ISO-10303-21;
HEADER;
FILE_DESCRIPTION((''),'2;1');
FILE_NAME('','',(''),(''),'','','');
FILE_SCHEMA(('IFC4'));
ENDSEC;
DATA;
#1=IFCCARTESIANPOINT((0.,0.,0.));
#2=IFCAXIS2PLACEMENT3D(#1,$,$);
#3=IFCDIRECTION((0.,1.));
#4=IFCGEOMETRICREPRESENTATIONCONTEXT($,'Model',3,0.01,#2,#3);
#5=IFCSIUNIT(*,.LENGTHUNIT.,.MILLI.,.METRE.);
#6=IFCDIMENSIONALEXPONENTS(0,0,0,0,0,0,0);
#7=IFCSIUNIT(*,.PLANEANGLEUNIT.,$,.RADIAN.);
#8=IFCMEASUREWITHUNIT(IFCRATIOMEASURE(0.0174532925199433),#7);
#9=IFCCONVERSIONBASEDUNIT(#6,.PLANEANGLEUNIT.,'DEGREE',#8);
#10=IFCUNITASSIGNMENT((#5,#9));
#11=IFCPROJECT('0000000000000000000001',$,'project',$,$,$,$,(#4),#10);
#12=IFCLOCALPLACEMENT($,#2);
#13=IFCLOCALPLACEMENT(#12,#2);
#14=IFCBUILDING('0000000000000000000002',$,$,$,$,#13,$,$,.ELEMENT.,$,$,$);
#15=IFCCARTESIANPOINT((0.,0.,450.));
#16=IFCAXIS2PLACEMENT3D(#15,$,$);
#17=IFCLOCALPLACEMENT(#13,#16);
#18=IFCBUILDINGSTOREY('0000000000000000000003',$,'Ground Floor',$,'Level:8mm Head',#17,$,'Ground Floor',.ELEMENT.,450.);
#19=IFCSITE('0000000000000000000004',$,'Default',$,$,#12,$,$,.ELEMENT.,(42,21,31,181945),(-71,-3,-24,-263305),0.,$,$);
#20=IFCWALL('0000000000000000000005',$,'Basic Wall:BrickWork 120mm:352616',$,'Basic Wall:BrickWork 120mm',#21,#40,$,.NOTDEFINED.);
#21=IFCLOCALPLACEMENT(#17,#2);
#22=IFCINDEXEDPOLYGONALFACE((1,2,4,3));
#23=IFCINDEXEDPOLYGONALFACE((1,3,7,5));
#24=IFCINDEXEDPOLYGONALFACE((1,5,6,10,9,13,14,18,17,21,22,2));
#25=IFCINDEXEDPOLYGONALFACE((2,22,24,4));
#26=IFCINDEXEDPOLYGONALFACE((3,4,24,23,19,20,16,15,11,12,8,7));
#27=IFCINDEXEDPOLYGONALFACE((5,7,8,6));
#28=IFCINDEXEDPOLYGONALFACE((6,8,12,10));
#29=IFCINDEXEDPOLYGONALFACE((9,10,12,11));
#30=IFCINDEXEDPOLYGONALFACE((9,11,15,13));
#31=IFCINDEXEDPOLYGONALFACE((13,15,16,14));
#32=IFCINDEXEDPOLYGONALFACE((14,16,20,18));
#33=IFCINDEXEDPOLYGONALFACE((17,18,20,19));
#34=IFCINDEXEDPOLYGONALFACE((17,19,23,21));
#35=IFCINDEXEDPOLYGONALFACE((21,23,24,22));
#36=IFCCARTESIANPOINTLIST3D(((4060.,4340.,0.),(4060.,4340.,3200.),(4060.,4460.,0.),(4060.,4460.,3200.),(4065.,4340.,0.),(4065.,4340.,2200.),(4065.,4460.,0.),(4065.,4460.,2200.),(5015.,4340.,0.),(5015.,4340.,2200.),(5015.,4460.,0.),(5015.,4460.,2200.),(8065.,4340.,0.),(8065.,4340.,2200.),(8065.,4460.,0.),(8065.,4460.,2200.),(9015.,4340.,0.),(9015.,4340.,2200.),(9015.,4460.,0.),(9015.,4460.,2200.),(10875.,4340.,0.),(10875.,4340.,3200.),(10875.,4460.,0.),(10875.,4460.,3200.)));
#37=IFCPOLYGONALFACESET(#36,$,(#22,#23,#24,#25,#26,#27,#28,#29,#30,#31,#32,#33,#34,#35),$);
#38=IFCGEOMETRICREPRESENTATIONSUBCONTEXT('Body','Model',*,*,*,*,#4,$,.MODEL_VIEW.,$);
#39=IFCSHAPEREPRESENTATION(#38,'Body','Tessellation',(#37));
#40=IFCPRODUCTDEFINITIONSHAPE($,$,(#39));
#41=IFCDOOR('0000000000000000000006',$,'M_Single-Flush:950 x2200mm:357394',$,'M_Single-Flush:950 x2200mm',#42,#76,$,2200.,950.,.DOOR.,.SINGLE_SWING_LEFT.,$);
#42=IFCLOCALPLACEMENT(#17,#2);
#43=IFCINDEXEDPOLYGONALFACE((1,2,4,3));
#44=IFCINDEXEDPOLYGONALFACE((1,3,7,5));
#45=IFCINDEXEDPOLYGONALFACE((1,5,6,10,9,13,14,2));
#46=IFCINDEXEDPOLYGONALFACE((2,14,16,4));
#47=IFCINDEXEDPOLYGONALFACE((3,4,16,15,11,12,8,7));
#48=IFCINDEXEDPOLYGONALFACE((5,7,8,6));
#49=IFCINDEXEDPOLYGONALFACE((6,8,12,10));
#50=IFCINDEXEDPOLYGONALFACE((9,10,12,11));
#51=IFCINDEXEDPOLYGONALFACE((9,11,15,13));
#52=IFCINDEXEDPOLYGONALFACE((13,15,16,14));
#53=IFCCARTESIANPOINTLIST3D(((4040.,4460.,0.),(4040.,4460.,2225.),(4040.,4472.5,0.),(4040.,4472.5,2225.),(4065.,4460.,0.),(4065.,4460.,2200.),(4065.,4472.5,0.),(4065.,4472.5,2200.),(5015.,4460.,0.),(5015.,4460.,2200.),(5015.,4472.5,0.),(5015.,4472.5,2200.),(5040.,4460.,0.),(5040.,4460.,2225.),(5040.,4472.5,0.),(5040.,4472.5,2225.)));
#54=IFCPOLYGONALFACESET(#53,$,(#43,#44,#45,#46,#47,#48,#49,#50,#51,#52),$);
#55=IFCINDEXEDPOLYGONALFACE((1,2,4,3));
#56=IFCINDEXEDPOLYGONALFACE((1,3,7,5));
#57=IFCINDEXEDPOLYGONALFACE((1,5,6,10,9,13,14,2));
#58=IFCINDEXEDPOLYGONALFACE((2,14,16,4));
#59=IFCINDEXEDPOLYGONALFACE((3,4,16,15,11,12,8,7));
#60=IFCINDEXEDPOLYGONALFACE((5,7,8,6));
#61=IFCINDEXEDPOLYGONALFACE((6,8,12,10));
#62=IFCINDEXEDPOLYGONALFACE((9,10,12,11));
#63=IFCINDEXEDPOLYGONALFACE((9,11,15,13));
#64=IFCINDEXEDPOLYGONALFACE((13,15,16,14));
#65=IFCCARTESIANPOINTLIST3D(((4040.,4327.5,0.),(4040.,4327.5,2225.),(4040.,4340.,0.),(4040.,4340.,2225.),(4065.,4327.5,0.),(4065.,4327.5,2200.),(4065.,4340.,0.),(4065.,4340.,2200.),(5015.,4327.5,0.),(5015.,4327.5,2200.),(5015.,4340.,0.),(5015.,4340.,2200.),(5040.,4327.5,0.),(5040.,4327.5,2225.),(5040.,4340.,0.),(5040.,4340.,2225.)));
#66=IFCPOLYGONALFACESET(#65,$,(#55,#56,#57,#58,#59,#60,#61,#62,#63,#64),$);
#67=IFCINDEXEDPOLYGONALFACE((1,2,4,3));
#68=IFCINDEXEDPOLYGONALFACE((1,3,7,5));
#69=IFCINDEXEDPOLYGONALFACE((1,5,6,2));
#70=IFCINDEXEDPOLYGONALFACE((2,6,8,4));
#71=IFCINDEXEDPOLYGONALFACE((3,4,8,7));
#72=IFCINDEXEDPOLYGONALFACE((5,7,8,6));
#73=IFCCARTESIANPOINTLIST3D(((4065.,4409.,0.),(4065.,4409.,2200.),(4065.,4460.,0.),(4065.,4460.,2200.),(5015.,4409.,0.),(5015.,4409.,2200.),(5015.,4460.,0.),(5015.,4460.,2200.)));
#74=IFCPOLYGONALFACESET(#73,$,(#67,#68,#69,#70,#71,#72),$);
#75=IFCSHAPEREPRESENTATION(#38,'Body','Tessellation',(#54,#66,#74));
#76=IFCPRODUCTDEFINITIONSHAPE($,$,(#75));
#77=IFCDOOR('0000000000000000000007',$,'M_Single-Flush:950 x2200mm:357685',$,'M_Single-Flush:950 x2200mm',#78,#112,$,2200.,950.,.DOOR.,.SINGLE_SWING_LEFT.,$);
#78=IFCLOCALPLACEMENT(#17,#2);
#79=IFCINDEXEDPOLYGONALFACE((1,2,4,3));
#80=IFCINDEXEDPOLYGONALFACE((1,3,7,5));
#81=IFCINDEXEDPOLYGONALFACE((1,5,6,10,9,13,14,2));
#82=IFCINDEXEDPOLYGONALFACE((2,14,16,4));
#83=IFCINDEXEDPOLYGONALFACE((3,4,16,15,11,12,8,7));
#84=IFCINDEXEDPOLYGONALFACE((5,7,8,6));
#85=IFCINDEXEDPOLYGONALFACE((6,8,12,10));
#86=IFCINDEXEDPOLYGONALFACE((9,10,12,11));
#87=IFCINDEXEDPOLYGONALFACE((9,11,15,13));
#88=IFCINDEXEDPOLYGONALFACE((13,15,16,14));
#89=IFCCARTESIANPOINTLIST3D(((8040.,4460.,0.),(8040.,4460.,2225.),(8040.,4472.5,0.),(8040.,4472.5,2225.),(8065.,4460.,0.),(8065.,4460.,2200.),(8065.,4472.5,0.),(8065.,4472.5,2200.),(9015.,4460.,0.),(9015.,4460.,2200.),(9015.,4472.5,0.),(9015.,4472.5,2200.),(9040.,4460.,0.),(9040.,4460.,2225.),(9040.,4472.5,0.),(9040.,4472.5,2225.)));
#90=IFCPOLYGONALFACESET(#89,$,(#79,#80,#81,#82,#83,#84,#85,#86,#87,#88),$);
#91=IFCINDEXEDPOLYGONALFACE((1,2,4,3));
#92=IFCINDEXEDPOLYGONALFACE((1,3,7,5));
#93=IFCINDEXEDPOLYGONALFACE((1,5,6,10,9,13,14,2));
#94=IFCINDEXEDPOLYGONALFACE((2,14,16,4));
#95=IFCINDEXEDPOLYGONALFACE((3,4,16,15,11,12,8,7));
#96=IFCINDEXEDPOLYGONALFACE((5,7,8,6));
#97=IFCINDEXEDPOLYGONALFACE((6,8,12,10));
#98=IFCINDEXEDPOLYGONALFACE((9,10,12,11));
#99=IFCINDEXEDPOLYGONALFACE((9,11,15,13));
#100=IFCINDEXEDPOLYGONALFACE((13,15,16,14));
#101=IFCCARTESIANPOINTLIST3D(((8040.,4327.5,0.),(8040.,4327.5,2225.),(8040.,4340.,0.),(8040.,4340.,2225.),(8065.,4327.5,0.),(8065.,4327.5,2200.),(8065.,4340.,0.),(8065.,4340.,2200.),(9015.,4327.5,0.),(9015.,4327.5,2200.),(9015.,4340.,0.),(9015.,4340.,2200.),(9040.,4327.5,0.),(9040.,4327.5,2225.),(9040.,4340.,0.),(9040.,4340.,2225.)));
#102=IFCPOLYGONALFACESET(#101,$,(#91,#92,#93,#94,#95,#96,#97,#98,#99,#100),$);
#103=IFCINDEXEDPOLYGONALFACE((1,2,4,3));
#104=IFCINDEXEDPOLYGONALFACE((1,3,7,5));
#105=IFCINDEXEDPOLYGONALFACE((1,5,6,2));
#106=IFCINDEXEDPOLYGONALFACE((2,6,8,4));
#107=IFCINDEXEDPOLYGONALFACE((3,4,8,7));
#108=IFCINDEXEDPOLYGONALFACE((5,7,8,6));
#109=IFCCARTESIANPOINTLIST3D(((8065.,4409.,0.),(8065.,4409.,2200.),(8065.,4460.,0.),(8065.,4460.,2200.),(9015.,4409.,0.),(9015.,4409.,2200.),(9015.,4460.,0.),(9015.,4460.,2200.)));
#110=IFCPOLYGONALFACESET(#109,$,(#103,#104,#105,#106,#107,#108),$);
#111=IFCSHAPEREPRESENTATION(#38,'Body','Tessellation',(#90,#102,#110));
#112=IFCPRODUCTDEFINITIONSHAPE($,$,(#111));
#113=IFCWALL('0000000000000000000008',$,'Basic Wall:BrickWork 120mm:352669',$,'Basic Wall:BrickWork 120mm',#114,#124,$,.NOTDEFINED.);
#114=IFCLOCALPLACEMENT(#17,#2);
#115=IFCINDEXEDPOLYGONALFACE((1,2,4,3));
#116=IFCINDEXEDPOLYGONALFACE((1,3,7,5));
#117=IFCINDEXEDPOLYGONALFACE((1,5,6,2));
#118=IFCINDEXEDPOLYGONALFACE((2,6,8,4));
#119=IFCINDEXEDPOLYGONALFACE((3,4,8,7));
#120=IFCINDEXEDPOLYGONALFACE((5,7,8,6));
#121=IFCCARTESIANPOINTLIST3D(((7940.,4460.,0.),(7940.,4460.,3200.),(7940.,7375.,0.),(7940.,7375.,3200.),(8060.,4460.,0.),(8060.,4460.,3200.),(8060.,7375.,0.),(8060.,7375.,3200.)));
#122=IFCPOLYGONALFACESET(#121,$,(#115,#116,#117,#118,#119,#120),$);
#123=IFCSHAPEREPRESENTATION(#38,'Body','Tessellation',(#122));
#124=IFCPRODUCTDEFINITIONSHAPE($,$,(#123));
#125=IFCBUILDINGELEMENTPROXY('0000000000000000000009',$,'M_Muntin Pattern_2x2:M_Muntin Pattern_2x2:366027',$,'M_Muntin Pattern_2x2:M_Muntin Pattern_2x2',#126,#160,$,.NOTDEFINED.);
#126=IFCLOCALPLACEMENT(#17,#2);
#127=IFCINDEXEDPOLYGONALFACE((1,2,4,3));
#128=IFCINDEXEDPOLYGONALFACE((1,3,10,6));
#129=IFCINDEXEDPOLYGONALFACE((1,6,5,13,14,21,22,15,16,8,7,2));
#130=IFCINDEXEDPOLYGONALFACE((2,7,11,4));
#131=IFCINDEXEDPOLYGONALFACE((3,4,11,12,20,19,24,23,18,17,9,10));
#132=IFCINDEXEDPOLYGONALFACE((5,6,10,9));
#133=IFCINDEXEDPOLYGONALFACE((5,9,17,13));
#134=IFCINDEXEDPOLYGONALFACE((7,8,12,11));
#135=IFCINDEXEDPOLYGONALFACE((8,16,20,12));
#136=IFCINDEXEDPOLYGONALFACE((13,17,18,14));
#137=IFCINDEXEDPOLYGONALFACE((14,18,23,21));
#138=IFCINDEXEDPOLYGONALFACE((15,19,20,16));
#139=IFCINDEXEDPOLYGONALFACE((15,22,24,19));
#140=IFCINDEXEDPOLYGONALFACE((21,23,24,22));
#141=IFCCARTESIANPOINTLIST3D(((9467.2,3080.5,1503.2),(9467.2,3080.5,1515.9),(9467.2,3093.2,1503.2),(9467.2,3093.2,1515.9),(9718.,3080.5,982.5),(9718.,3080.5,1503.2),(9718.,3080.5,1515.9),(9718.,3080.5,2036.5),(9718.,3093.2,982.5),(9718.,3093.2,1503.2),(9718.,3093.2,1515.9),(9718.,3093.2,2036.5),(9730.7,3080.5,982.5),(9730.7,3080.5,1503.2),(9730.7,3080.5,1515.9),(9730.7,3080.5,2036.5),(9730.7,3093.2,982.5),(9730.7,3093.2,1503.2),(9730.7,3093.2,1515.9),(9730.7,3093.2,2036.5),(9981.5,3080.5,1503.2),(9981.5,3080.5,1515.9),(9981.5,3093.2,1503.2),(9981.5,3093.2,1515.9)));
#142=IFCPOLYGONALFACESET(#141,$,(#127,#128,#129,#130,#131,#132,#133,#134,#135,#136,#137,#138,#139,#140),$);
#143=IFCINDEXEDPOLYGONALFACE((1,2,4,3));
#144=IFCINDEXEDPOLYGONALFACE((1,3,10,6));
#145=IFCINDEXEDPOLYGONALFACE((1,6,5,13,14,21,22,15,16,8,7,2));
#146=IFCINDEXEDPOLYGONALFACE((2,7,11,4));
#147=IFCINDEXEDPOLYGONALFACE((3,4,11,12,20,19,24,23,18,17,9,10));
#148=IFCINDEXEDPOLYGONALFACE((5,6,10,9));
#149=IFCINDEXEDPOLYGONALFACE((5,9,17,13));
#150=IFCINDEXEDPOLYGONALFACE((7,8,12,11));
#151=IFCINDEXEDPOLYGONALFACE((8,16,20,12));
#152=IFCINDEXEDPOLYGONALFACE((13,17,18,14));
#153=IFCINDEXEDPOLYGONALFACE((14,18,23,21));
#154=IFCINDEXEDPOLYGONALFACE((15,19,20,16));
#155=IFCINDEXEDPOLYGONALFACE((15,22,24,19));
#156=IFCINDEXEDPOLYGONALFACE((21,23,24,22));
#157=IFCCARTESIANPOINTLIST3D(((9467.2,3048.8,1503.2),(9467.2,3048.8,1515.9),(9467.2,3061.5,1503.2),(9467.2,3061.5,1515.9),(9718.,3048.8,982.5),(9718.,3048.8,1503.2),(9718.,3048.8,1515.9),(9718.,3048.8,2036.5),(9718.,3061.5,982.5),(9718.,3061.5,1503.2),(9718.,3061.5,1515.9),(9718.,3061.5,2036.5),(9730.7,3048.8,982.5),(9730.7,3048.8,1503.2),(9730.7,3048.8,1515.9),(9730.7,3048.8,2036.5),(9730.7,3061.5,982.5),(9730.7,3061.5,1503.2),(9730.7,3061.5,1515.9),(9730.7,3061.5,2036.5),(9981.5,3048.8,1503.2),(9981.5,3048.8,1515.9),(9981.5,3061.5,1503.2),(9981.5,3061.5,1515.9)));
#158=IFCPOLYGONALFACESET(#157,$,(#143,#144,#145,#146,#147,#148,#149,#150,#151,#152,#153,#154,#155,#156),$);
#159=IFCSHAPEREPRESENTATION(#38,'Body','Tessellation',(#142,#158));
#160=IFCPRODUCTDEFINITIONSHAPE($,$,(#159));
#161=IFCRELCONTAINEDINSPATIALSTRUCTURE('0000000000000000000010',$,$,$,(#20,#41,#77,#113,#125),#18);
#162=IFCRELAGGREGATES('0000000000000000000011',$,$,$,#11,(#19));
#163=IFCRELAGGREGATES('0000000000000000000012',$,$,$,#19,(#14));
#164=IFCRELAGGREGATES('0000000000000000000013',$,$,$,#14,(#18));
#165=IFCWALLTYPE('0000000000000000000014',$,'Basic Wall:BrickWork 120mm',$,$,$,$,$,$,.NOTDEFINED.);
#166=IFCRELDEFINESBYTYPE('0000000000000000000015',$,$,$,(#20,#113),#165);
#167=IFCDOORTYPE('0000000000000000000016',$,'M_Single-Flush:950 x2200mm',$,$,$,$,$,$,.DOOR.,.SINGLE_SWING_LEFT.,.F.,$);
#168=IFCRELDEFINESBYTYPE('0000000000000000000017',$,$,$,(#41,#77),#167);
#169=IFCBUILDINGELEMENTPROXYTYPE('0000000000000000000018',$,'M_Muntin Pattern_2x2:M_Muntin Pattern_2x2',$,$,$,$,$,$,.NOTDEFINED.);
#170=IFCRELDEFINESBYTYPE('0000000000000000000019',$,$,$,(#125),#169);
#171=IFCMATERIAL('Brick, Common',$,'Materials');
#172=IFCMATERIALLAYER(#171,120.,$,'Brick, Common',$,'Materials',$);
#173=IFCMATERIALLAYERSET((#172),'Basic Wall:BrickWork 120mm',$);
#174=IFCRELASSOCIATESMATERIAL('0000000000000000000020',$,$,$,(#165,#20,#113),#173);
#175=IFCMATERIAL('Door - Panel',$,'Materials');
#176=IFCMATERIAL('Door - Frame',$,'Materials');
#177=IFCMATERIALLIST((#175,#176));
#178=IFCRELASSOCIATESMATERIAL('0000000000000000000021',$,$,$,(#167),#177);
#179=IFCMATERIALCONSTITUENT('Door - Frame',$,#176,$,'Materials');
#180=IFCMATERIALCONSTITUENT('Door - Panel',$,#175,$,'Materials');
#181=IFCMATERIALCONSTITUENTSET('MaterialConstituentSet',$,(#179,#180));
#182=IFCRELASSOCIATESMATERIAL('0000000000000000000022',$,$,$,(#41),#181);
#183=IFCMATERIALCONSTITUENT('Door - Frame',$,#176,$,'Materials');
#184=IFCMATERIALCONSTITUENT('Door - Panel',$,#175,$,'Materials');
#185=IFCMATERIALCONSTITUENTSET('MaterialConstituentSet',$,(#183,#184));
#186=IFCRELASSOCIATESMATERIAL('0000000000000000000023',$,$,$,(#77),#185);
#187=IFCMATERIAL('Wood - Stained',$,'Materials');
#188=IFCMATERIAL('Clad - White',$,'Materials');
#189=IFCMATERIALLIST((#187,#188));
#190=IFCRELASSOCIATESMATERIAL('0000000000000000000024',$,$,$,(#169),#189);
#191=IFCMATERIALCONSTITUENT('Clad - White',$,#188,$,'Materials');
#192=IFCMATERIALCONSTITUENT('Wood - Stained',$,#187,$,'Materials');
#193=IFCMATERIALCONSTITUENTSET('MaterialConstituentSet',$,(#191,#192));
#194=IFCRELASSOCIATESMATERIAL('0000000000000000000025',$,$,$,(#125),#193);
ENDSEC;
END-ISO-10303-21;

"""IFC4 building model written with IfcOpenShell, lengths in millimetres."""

from ifc_helpers import new_model, entity, si_unit, converted_unit, direction, frame, frame_2d, origin, place, context, subcontext, project, spatial, polyline, rectangle, outline, extrude, source, transform, mapped, material, material_list, layer, layer_set, layer_usage, constituent, constituent_set, type_object, type_shapes, element, fill, save


model = new_model("IFC4")

# Units and contexts
model_context = context("Model", 3, precision=0.01, world=origin(), true_north=direction((0.0, 1.0)))
body_context = subcontext(model_context, "Body", "Model", "MODEL_VIEW")
ifc_project = project(units=[si_unit("LENGTHUNIT", "METRE", prefix="MILLI"), converted_unit("PLANEANGLEUNIT", "DEGREE", entity("IfcRatioMeasure", 0.0174532925199433), si_unit("PLANEANGLEUNIT", "RADIAN"), dimensions=[0, 0, 0, 0, 0, 0, 0])], contexts=[model_context])

# Site, building, storey
site_placement = place(None, origin())
site = spatial("IfcSite", under=ifc_project, at=site_placement, Name="Default", CompositionType="ELEMENT", RefLatitude=(42, 21, 31, 181945), RefLongitude=(-71, -3, -24, -263305), RefElevation=0.0)
building_placement = place(site_placement, origin())
building = spatial("IfcBuilding", under=site, at=building_placement, CompositionType="ELEMENT")
storey_placement = place(building_placement, frame((0.0, 0.0, 450.0)))
storey = spatial("IfcBuildingStorey", under=building, at=storey_placement, Name="Ground Floor", ObjectType="Level:8mm Head", LongName="Ground Floor", CompositionType="ELEMENT", Elevation=450.0)

# Shared definitions
ifc_material_1 = material(Name="Brick, Common", Category="Materials")

# Wall, openings, doors
ifc_layer_1 = layer(ifc_material_1, 120.0, Name="Brick, Common", Category="Materials")
ifc_layer_set_1 = layer_set([ifc_layer_1], Name="Basic Wall:BrickWork 120mm")
ifc_layer_usage_1 = layer_usage(ifc_layer_set_1, "AXIS2", "NEGATIVE", 60.0)
wall_type_1 = type_object("IfcWallType", Name="Basic Wall:BrickWork 120mm", PredefinedType="NOTDEFINED", material=ifc_layer_set_1)
wall_1_placement = place(storey_placement, frame((10875.0, 4400.0, 0.0), z_axis=(0.0, 0.0, 1.0), x_axis=(-1.0, 0.0, 0.0)))
wall_1 = element("IfcWall", 1, at=wall_1_placement, inside=storey, type_object=wall_type_1, material=ifc_layer_usage_1, Name="Basic Wall:BrickWork 120mm:352616", ObjectType="Basic Wall:BrickWork 120mm", PredefinedType="NOTDEFINED", context=body_context, shape_type="SweptSolid", body=[
    extrude(rectangle(XDim=6815.0, YDim=120.0, at=frame_2d((3407.5, 0.0), x_axis=(-1.0, 0.0))), origin(), (0.0, 0.0, 1.0), 3200.0),
])
opening_1_placement = place(wall_1_placement, frame((6810.0, 60.0, 0.0)))
opening_1 = element("IfcOpeningElement", 2, at=opening_1_placement, cuts=wall_1, ObjectType="Opening", PredefinedType="OPENING", context=body_context, shape_type="SweptSolid", body=[
    extrude(rectangle(XDim=950.0, YDim=2200.0, at=frame_2d((1100.0, 475.0), x_axis=(0.0, -1.0))), frame((0.0, 0.0, 0.0), z_axis=(0.0, -1.0, 0.0), x_axis=(0.0, 0.0, 1.0)), (0.0, 0.0, 1.0), 120.0),
])
opening_2_placement = place(wall_1_placement, frame((2810.0, 60.0, 0.0)))
opening_2 = element("IfcOpeningElement", 3, at=opening_2_placement, cuts=wall_1, ObjectType="Opening", PredefinedType="OPENING", context=body_context, shape_type="SweptSolid", body=[
    extrude(rectangle(XDim=950.0, YDim=2200.0, at=frame_2d((1100.0, 475.0), x_axis=(0.0, -1.0))), frame((0.0, 0.0, 0.0), z_axis=(0.0, -1.0, 0.0), x_axis=(0.0, 0.0, 1.0)), (0.0, 0.0, 1.0), 120.0),
])
ifc_material_2 = material(Name="Door - Frame", Category="Materials")
ifc_constituent_1 = constituent(ifc_material_2, Name="Door - Frame", Category="Materials")
ifc_material_3 = material(Name="Door - Panel", Category="Materials")
ifc_constituent_2 = constituent(ifc_material_3, Name="Door - Panel", Category="Materials")
ifc_constituent_set_1 = constituent_set(constituents=[ifc_constituent_1, ifc_constituent_2], Name="MaterialConstituentSet")
ifc_material_list_1 = material_list([ifc_material_3, ifc_material_2])
door_type_1 = type_object("IfcDoorType", Name="M_Single-Flush:950 x2200mm", OperationType="SINGLE_SWING_LEFT", ParameterTakesPrecedence=False, PredefinedType="DOOR", material=ifc_material_list_1)
shared_shape_1 = source(origin(), body_context, "Body", "SweptSolid", [
    extrude(outline(polyline([(-500.0, -1118.8), (500.0, -1118.8), (500.0, 1106.2), (475.0, 1106.2), (475.0, -1093.8), (-475.0, -1093.8), (-475.0, 1106.2), (-500.0, 1106.2), (-500.0, -1118.8)])), frame((475.0, 132.5, 1106.2), z_axis=(0.0, -1.0, 0.0), x_axis=(-1.0, 0.0, 0.0)), (0.0, 0.0, 1.0), 12.5),
    extrude(outline(polyline([(-1118.8, -500.0), (1106.2, -500.0), (1106.2, -475.0), (-1093.8, -475.0), (-1093.8, 475.0), (1106.2, 475.0), (1106.2, 500.0), (-1118.8, 500.0), (-1118.8, -500.0)])), frame((475.0, 0.0, 1106.2), z_axis=(0.0, -1.0, 0.0), x_axis=(0.0, 0.0, -1.0)), (0.0, 0.0, 1.0), 12.5),
    extrude(rectangle(XDim=950.0, YDim=51.0, at=frame_2d((0.0, 0.0), x_axis=(1.0, 0.0))), frame((475.0, 94.5, 0.0)), (0.0, 0.0, 1.0), 2200.0),
])
type_shapes(door_type_1, [shared_shape_1])
door_1_placement = place(opening_1_placement, frame((0.0, 0.0, 0.0), z_axis=(0.0, 0.0, 1.0), x_axis=(-1.0, 0.0, 0.0)))
door_1 = element("IfcDoor", 4, at=door_1_placement, inside=storey, type_object=door_type_1, material=ifc_constituent_set_1, Name="M_Single-Flush:950 x2200mm:357394", ObjectType="M_Single-Flush:950 x2200mm", OperationType="SINGLE_SWING_LEFT", OverallHeight=2200.0, OverallWidth=950.0, PredefinedType="DOOR", context=body_context, shape_type="MappedRepresentation", body=[
    mapped(shared_shape_1, transform((0.0, 0.0, 0.0), scale=1.0)),
])
fill(opening_1, door_1)
ifc_constituent_3 = constituent(ifc_material_2, Name="Door - Frame", Category="Materials")
ifc_constituent_4 = constituent(ifc_material_3, Name="Door - Panel", Category="Materials")
ifc_constituent_set_2 = constituent_set(constituents=[ifc_constituent_3, ifc_constituent_4], Name="MaterialConstituentSet")
door_2_placement = place(opening_2_placement, frame((0.0, 0.0, 0.0), z_axis=(0.0, 0.0, 1.0), x_axis=(-1.0, 0.0, 0.0)))
door_2 = element("IfcDoor", 5, at=door_2_placement, inside=storey, type_object=door_type_1, material=ifc_constituent_set_2, Name="M_Single-Flush:950 x2200mm:357685", ObjectType="M_Single-Flush:950 x2200mm", OperationType="SINGLE_SWING_LEFT", OverallHeight=2200.0, OverallWidth=950.0, PredefinedType="DOOR", context=body_context, shape_type="MappedRepresentation", body=[
    mapped(shared_shape_1, transform((0.0, 0.0, 0.0), scale=1.0)),
])
fill(opening_2, door_2)

# Wall
ifc_layer_usage_2 = layer_usage(ifc_layer_set_1, "AXIS2", "NEGATIVE", 60.0)
wall_2_placement = place(storey_placement, frame((8000.0, 7375.0, 0.0), z_axis=(0.0, 0.0, 1.0), x_axis=(0.0, -1.0, 0.0)))
element("IfcWall", 6, at=wall_2_placement, inside=storey, type_object=wall_type_1, material=ifc_layer_usage_2, Name="Basic Wall:BrickWork 120mm:352669", ObjectType="Basic Wall:BrickWork 120mm", PredefinedType="NOTDEFINED", context=body_context, shape_type="SweptSolid", body=[
    extrude(rectangle(XDim=2915.0, YDim=120.0, at=frame_2d((1457.5, 0.0), x_axis=(-1.0, 0.0))), origin(), (0.0, 0.0, 1.0), 3200.0),
])

# Building element proxy
ifc_material_4 = material(Name="Clad - White", Category="Materials")
ifc_constituent_5 = constituent(ifc_material_4, Name="Clad - White", Category="Materials")
ifc_material_5 = material(Name="Wood - Stained", Category="Materials")
ifc_constituent_6 = constituent(ifc_material_5, Name="Wood - Stained", Category="Materials")
ifc_constituent_set_3 = constituent_set(constituents=[ifc_constituent_5, ifc_constituent_6], Name="MaterialConstituentSet")
ifc_material_list_2 = material_list([ifc_material_5, ifc_material_4])
building_element_proxy_type_1 = type_object("IfcBuildingElementProxyType", Name="M_Muntin Pattern_2x2:M_Muntin Pattern_2x2", PredefinedType="NOTDEFINED", material=ifc_material_list_2)
shared_shape_2 = source(origin(), body_context, "Body", "SweptSolid", [
    extrude(outline(polyline([(6.4, -6.4), (527.0, -6.4), (527.0, 6.3), (6.4, 6.3), (6.4, 257.1), (-6.3, 257.1), (-6.3, 6.3), (-527.0, 6.3), (-527.0, -6.4), (-6.3, -6.4), (-6.3, -257.1), (6.4, -257.1), (6.4, -6.4)])), frame((0.0, 9.5, 527.0), z_axis=(0.0, 1.0, 0.0), x_axis=(0.0, 0.0, 1.0)), (0.0, 0.0, 1.0), 12.7),
    extrude(outline(polyline([(6.4, -6.4), (527.0, -6.4), (527.0, 6.3), (6.4, 6.3), (6.4, 257.1), (-6.3, 257.1), (-6.3, 6.3), (-527.0, 6.3), (-527.0, -6.4), (-6.3, -6.4), (-6.3, -257.1), (6.4, -257.1), (6.4, -6.4)])), frame((0.0, -22.2, 527.0), z_axis=(0.0, 1.0, 0.0), x_axis=(0.0, 0.0, 1.0)), (0.0, 0.0, 1.0), 12.7),
])
type_shapes(building_element_proxy_type_1, [shared_shape_2])
proxy_1_placement = place(storey_placement, frame((9724.4, 3071.0, 982.5)))
element("IfcBuildingElementProxy", 7, at=proxy_1_placement, inside=storey, type_object=building_element_proxy_type_1, material=ifc_constituent_set_3, Name="M_Muntin Pattern_2x2:M_Muntin Pattern_2x2:366027", ObjectType="M_Muntin Pattern_2x2:M_Muntin Pattern_2x2", PredefinedType="NOTDEFINED", context=body_context, shape_type="MappedRepresentation", body=[
    mapped(shared_shape_2, transform((0.0, 0.0, 0.0), scale=1.0)),
])

save(model, "model.ifc")
